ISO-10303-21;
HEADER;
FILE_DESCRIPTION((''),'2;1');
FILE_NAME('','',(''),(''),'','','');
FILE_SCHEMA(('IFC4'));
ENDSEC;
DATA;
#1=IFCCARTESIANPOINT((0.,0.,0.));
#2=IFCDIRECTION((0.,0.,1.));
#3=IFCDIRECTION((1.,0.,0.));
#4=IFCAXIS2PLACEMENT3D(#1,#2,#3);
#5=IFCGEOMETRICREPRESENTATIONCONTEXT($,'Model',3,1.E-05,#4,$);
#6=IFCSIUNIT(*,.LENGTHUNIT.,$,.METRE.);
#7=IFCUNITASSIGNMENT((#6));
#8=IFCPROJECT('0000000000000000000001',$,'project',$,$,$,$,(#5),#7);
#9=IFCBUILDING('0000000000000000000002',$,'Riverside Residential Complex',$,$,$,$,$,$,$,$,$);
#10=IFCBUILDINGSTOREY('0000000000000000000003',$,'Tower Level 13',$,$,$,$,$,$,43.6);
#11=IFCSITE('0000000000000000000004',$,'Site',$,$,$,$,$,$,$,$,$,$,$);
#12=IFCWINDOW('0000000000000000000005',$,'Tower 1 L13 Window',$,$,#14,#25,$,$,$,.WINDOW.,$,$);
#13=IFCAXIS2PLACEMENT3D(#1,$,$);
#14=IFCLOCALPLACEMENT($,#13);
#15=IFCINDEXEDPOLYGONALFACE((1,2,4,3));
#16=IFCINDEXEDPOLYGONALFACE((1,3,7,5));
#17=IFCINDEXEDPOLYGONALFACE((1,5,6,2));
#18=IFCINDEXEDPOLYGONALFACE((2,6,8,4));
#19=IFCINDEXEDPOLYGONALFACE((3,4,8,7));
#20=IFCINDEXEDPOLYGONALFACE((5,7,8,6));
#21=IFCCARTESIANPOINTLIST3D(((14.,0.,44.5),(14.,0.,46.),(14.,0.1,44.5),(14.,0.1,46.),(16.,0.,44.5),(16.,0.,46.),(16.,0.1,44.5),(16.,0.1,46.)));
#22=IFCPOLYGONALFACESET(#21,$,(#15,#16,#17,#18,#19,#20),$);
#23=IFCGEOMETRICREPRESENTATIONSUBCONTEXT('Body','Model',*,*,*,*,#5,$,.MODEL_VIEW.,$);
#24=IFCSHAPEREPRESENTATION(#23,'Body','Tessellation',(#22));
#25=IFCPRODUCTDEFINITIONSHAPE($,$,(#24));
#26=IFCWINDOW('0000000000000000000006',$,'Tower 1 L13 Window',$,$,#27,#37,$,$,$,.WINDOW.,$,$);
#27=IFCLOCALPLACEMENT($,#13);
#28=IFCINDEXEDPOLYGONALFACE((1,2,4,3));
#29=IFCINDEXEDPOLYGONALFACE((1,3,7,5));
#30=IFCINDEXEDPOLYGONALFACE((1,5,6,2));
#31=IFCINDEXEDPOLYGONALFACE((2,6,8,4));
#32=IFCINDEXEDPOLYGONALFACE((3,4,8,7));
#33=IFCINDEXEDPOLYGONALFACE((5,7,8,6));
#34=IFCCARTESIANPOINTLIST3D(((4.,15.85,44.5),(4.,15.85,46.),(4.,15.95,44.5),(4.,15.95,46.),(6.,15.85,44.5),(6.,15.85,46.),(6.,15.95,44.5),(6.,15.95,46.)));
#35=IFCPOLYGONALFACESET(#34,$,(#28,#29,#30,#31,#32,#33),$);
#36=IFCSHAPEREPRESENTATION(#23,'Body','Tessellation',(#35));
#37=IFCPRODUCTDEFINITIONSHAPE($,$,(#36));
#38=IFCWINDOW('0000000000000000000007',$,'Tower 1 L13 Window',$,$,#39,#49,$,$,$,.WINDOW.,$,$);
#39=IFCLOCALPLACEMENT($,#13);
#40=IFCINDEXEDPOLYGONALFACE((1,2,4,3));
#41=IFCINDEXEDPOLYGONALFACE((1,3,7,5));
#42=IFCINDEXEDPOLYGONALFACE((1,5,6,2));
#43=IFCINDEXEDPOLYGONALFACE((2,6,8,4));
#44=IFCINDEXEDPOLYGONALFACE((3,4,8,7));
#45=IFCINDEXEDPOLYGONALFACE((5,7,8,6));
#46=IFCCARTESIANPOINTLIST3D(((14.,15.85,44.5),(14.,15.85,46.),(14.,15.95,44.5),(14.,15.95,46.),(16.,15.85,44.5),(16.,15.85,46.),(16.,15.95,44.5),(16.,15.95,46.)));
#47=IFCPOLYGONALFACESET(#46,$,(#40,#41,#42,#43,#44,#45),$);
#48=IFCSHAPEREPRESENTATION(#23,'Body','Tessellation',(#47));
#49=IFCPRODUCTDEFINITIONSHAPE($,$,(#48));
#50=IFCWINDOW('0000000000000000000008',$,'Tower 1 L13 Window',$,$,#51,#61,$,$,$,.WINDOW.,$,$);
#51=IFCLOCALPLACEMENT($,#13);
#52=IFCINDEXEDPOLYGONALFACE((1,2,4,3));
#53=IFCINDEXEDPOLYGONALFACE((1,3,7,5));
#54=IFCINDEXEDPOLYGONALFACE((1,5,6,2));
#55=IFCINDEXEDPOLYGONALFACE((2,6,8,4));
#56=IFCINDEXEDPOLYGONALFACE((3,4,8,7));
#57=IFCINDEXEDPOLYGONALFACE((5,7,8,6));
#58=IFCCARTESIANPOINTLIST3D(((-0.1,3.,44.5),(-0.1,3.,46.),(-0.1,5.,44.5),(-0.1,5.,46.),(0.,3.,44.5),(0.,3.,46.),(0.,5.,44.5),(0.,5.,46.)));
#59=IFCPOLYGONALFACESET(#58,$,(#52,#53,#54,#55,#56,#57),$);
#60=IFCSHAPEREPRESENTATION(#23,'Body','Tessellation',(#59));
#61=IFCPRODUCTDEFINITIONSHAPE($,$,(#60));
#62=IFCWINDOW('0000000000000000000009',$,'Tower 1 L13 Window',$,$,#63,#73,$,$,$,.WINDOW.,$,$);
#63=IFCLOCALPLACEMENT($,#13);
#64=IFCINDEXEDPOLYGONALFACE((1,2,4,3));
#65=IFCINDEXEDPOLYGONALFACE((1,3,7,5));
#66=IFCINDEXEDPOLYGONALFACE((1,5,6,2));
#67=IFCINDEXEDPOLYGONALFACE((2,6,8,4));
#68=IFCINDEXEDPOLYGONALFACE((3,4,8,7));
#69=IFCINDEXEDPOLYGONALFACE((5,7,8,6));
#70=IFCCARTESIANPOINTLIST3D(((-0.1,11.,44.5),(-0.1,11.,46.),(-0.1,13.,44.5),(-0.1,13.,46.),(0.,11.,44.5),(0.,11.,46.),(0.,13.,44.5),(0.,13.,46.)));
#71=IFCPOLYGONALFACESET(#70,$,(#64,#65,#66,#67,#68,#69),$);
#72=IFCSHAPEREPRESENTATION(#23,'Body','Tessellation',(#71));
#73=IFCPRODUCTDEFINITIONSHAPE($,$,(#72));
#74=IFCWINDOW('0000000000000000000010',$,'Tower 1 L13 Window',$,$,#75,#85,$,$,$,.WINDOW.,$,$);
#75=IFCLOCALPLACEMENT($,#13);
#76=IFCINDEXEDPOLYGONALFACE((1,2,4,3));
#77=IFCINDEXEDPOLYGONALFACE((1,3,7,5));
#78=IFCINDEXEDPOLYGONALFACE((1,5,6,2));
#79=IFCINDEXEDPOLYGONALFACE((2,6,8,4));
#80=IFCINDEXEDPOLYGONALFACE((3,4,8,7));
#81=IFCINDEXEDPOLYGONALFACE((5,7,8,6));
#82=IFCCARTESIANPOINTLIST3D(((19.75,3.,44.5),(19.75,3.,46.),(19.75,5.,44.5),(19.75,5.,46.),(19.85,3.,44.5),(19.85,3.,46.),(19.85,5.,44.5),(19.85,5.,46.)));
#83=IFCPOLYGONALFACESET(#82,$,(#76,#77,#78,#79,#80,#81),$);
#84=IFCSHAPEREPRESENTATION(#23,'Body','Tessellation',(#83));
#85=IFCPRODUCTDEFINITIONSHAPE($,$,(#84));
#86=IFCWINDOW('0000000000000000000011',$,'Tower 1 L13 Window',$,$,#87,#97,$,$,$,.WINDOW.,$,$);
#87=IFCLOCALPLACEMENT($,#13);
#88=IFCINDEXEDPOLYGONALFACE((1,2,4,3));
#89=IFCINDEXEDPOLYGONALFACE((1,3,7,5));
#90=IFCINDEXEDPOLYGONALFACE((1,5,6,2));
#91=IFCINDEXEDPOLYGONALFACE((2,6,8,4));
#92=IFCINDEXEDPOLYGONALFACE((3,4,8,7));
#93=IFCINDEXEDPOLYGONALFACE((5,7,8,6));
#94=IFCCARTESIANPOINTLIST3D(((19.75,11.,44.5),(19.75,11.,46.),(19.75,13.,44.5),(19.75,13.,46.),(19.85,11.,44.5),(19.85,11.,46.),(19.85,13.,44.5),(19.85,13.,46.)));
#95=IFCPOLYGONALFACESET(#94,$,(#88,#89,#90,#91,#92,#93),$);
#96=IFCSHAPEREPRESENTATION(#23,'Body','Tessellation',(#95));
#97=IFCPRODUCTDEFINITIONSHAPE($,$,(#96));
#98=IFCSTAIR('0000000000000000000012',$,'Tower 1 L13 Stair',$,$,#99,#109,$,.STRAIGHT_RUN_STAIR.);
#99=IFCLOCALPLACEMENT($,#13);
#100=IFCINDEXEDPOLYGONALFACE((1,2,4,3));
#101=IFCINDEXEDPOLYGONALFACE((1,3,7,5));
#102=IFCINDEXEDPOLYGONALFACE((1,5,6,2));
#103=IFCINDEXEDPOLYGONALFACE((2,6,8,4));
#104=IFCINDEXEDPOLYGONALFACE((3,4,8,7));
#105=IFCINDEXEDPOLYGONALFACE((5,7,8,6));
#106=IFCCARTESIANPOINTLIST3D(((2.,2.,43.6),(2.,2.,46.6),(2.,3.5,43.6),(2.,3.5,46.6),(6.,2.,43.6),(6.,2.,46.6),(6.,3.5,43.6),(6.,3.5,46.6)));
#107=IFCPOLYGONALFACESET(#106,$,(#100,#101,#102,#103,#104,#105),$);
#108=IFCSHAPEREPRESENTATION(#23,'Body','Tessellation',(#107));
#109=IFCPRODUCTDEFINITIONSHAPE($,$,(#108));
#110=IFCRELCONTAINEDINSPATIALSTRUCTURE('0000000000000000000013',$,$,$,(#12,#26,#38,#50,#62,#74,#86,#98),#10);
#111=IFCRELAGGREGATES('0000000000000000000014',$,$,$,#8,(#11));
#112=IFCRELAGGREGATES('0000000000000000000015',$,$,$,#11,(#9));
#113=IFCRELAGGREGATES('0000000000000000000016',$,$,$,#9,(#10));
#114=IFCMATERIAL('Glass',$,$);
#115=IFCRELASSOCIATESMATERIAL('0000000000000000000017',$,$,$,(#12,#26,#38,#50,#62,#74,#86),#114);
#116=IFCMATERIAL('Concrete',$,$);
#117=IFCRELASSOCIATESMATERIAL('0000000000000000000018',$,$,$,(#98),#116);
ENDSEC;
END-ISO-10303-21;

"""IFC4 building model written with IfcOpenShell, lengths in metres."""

from ifc_helpers import new_model, si_unit, frame, origin_with_axes, place, context, subcontext, project, spatial, line, indexed_curve, outline, extrude, material, element, save


model = new_model("IFC4")

# Units and contexts
model_context = context("Model", 3, precision=1e-05, world=origin_with_axes())
body_context = subcontext(model_context, "Body", "Model", "MODEL_VIEW")
ifc_project = project(units=[si_unit("LENGTHUNIT", "METRE")], contexts=[model_context])

# Site, building, storey
site = spatial("IfcSite", under=ifc_project, Name="Site")
building = spatial("IfcBuilding", under=site, Name="Riverside Residential Complex")
storey = spatial("IfcBuildingStorey", under=building, Name="Tower Level 13", Elevation=43.6)

# Shared definitions
ifc_material_1 = material(Name="Concrete")

# Windows
ifc_material_2 = material(Name="Glass")
for number, where, z_axis, x_axis, name in (
    (1, (14.0, 0.0, 44.5), (0.0, 0.0, 1.0), (1.0, 0.0, 0.0), "Tower 1 L13 Window"),
    (2, (4.0, 15.85, 44.5), (0.0, 0.0, 1.0), (1.0, 0.0, 0.0), "Tower 1 L13 Window"),
    (3, (14.0, 15.85, 44.5), (0.0, 0.0, 1.0), (1.0, 0.0, 0.0), "Tower 1 L13 Window"),
    (4, (0.0, 3.0, 44.5), (0.0, 0.0, 1.0), (0.0, 1.0, 0.0), "Tower 1 L13 Window"),
    (5, (0.0, 11.0, 44.5), (0.0, 0.0, 1.0), (0.0, 1.0, 0.0), "Tower 1 L13 Window"),
    (6, (19.85, 3.0, 44.5), (0.0, 0.0, 1.0), (0.0, 1.0, 0.0), "Tower 1 L13 Window"),
    (7, (19.85, 11.0, 44.5), (0.0, 0.0, 1.0), (0.0, 1.0, 0.0), "Tower 1 L13 Window"),
):
    element("IfcWindow", number, at=place(None, frame(where, z_axis=z_axis, x_axis=x_axis)), inside=storey, material=ifc_material_2, Name=name, PredefinedType="WINDOW", context=body_context, shape_type="SweptSolid", body=[
        extrude(outline(indexed_curve([(0.0, 0.0), (2.0, 0.0), (2.0, 0.1), (0.0, 0.1)], segments=[line(1, 2, 3, 4, 1)])), origin_with_axes(), (0.0, 0.0, 1.0), 1.5),
    ])

# Stair
stair_placement = place(None, frame((2.0, 2.0, 43.6), z_axis=(0.0, 0.0, 1.0), x_axis=(1.0, 0.0, 0.0)))
element("IfcStair", 8, at=stair_placement, inside=storey, material=ifc_material_1, Name="Tower 1 L13 Stair", PredefinedType="STRAIGHT_RUN_STAIR", context=body_context, shape_type="SweptSolid", body=[
    extrude(outline(indexed_curve([(0.0, 0.0), (4.0, 0.0), (4.0, 1.5), (0.0, 1.5)], segments=[line(1, 2, 3, 4, 1)])), origin_with_axes(), (0.0, 0.0, 1.0), 3.0),
])

save(model, "model.ifc")
